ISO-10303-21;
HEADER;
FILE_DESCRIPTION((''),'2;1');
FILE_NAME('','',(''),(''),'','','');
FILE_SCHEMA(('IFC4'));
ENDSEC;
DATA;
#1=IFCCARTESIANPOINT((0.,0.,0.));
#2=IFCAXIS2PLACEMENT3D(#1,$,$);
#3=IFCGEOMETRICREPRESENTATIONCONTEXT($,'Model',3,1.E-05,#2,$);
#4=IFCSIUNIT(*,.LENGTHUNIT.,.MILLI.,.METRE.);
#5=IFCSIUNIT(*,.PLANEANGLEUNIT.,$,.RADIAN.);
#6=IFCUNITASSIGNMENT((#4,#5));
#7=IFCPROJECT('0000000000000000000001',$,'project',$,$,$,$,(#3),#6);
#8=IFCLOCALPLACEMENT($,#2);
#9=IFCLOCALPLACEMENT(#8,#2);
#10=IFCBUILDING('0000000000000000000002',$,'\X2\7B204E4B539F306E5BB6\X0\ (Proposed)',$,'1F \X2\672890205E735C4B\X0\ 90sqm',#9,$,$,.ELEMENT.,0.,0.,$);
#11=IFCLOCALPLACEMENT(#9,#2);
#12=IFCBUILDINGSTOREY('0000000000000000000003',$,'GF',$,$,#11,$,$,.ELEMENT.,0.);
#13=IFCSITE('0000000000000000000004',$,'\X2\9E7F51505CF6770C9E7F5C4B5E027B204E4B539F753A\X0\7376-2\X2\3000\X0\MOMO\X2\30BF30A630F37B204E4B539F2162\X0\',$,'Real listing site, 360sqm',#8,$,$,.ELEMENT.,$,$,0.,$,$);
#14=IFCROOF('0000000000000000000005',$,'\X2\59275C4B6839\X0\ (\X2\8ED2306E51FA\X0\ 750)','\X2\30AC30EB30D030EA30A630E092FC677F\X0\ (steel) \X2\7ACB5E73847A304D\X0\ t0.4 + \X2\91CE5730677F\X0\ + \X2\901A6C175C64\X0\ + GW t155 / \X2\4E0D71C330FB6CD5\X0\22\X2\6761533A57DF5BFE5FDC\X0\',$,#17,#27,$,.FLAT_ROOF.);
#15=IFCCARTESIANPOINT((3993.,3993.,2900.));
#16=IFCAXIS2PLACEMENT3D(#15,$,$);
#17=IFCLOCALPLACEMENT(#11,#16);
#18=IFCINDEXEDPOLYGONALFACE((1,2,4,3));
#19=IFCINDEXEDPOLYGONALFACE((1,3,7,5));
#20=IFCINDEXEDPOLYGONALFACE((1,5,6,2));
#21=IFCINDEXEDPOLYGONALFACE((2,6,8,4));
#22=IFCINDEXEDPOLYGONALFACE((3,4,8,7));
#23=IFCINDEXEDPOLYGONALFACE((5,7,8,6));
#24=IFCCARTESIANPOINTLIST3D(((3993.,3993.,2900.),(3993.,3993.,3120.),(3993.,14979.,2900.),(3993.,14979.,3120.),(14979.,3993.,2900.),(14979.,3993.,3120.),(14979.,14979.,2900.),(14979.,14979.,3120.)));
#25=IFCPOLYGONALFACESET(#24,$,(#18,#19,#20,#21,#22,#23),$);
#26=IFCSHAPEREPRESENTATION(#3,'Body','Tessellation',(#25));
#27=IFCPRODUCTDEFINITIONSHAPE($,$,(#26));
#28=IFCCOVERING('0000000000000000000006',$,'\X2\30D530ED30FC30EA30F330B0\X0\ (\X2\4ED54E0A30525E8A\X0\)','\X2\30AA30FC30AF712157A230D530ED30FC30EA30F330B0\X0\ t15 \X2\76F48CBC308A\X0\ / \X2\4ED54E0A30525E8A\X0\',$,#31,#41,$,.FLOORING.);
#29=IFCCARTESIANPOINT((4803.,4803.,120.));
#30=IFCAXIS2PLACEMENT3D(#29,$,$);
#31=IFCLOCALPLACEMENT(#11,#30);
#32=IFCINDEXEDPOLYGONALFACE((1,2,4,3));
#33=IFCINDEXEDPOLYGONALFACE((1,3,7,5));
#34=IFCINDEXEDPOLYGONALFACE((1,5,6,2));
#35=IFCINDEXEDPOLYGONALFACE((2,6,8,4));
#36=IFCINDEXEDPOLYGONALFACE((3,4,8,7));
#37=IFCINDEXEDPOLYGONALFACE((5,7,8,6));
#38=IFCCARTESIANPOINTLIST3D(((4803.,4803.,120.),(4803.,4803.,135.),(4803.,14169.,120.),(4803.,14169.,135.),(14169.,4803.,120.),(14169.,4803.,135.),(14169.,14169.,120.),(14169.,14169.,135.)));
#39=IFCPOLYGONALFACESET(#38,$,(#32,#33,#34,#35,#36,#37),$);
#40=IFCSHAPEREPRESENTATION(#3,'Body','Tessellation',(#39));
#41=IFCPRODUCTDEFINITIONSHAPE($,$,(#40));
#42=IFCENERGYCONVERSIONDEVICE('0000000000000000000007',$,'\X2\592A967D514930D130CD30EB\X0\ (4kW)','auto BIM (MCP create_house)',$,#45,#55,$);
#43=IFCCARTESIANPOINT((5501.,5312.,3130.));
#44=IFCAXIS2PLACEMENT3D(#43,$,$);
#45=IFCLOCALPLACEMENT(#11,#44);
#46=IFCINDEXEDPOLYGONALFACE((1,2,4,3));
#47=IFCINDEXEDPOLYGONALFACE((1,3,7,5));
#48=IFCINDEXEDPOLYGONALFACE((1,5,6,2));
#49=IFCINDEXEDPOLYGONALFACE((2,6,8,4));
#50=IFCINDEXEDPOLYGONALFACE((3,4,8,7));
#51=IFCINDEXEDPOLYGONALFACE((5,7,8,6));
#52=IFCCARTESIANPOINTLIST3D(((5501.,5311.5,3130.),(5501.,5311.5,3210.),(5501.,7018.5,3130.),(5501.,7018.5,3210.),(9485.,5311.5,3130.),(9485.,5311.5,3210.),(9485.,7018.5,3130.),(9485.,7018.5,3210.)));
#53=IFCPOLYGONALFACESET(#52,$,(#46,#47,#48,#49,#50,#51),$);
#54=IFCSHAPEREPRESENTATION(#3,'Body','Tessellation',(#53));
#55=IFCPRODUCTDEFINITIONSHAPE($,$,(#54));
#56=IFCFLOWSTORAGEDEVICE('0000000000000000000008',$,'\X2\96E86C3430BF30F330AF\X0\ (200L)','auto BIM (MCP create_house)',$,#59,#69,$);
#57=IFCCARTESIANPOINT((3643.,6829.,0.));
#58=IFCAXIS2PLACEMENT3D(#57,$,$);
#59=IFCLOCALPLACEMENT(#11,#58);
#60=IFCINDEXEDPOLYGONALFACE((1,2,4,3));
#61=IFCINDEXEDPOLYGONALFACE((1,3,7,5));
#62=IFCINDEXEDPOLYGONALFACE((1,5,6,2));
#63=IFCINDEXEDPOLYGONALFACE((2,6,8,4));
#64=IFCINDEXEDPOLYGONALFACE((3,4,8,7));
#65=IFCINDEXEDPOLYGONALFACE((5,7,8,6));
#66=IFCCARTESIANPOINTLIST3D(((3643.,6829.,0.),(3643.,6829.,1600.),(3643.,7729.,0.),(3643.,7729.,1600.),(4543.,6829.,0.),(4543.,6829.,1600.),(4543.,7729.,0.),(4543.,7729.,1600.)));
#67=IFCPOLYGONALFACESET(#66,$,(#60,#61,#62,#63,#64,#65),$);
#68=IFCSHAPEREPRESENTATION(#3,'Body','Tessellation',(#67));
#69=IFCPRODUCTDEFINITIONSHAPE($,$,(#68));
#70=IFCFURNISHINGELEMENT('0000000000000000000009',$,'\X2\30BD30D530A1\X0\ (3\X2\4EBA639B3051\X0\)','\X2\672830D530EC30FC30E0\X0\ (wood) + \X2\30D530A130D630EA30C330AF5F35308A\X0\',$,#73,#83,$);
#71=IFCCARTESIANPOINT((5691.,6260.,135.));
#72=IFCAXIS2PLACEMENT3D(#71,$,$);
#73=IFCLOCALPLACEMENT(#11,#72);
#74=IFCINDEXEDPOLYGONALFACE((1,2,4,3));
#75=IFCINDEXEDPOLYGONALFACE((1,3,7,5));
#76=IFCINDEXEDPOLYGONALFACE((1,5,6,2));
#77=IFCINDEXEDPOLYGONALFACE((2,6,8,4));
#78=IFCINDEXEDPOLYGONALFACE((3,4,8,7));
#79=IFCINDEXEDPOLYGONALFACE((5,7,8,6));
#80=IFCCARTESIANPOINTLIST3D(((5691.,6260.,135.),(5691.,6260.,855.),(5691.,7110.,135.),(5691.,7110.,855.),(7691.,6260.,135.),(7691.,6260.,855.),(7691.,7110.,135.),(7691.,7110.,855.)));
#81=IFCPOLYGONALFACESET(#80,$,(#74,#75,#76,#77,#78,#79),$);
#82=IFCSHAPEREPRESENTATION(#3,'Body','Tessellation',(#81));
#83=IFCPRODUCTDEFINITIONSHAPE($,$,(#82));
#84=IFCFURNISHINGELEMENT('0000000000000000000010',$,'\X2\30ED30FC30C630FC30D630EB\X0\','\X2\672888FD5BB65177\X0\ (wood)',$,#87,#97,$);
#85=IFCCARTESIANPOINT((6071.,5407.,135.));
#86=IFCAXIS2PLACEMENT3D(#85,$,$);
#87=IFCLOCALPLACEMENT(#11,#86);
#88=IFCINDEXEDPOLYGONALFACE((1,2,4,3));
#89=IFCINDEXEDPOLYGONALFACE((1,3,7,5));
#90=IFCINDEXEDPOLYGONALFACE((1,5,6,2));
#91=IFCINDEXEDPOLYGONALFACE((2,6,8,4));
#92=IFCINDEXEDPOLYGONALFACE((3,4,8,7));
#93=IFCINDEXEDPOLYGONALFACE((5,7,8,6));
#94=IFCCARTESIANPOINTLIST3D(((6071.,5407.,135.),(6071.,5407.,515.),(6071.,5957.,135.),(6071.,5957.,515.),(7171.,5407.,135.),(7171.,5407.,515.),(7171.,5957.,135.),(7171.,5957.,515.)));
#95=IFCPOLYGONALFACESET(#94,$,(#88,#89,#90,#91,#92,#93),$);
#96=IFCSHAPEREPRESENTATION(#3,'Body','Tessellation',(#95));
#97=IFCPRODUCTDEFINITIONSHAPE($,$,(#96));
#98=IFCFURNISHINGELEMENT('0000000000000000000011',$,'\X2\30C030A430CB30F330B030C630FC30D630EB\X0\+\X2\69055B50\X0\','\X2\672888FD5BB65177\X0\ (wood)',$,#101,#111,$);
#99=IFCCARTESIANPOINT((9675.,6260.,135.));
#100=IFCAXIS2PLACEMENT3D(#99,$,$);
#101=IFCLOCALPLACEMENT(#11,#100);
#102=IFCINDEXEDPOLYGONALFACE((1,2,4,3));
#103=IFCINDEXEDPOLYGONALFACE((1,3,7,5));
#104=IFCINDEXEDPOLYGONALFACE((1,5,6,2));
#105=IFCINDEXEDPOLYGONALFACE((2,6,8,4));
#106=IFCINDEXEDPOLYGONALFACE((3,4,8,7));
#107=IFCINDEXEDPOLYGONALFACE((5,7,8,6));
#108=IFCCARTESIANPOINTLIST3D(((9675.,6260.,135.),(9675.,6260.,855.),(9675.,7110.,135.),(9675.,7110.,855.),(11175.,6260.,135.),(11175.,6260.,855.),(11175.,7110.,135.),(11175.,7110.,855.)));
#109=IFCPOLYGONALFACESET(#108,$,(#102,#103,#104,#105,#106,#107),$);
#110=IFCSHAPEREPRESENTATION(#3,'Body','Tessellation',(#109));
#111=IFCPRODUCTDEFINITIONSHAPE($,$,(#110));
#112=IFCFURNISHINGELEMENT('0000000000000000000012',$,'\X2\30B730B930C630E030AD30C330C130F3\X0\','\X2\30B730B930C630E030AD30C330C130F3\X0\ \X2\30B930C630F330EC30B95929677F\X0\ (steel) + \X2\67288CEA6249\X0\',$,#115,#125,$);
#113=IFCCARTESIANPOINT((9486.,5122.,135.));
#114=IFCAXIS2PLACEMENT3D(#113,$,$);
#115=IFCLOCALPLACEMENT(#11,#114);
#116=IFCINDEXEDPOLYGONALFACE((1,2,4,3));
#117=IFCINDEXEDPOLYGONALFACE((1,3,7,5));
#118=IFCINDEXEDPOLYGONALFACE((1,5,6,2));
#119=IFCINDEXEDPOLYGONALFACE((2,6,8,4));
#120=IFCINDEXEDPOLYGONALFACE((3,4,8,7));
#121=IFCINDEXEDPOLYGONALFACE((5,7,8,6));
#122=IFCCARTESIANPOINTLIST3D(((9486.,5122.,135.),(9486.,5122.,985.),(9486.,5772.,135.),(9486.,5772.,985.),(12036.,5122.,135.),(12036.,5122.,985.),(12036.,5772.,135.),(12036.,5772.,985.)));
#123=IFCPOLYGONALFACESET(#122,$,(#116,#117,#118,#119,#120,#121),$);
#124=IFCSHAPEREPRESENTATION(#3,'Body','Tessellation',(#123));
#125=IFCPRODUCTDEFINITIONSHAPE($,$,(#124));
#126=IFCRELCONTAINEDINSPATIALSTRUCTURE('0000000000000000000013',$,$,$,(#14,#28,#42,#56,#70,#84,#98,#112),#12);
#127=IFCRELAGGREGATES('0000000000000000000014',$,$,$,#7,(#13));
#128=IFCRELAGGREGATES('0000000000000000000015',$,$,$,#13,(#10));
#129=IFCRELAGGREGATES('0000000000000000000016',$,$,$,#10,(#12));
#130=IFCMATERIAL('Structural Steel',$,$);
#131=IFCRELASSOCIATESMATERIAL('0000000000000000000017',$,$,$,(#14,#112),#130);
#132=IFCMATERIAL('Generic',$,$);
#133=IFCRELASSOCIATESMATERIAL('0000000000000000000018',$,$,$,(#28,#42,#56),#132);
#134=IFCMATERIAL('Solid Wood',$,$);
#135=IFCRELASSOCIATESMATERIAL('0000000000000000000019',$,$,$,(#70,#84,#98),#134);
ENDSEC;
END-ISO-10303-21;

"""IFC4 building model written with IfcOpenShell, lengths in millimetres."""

from ifc_helpers import new_model, si_unit, frame, frame_2d, origin, place, context, project, spatial, rectangle, extrude, material, element, save


model = new_model("IFC4")

# Units and contexts
model_context = context("Model", 3, precision=1e-05, world=origin())
ifc_project = project(units=[si_unit("LENGTHUNIT", "METRE", prefix="MILLI"), si_unit("PLANEANGLEUNIT", "RADIAN")], contexts=[model_context])

# Site, building, storey
site_placement = place(None, origin())
site = spatial("IfcSite", under=ifc_project, at=site_placement, Name="鹿児島県鹿屋市笠之原町7376-2　MOMOタウン笠之原Ⅲ", ObjectType="Real listing site, 360sqm", CompositionType="ELEMENT", RefElevation=0.0)
building_placement = place(site_placement, origin())
building = spatial("IfcBuilding", under=site, at=building_placement, Name="笠之原の家 (Proposed)", ObjectType="1F 木造平屋 90sqm", CompositionType="ELEMENT", ElevationOfRefHeight=0.0, ElevationOfTerrain=0.0)
storey_placement = place(building_placement, origin())
storey = spatial("IfcBuildingStorey", under=building, at=storey_placement, Name="GF", CompositionType="ELEMENT", Elevation=0.0)

# Shared definitions
ifc_material_1 = material(Name="Solid Wood")

# Roof
ifc_material_2 = material(Name="Structural Steel")
roof_placement = place(storey_placement, frame((3993.0, 3993.0, 2900.0)))
element("IfcRoof", 1, at=roof_placement, inside=storey, material=ifc_material_2, Name="大屋根 (軒の出 750)", Description="ガルバリウム鋼板 (steel) 立平葺き t0.4 + 野地板 + 通気層 + GW t155 / 不燃・法22条区域対応", PredefinedType="FLAT_ROOF", context=model_context, shape_type="SweptSolid", body=[
    extrude(rectangle(XDim=10986.0, YDim=10986.0, at=frame_2d((5493.0, 5493.0))), frame((3993.0, 3993.0, 2900.0)), (0.0, 0.0, 1.0), 220.0),
])

# Covering
ifc_material_3 = material(Name="Generic")
covering_placement = place(storey_placement, frame((4803.0, 4803.0, 120.0)))
element("IfcCovering", 2, at=covering_placement, inside=storey, material=ifc_material_3, Name="フローリング (仕上げ床)", Description="オーク無垢フローリング t15 直貼り / 仕上げ床", PredefinedType="FLOORING", context=model_context, shape_type="SweptSolid", body=[
    extrude(rectangle(XDim=9366.0, YDim=9366.0, at=frame_2d((4683.0, 4683.0))), frame((4803.0, 4803.0, 120.0)), (0.0, 0.0, 1.0), 15.0),
])

# Energy conversion device
energy_conversion_device_placement = place(storey_placement, frame((5501.0, 5312.0, 3130.0)))
element("IfcEnergyConversionDevice", 3, at=energy_conversion_device_placement, inside=storey, material=ifc_material_3, Name="太陽光パネル (4kW)", Description="auto BIM (MCP create_house)", context=model_context, shape_type="SweptSolid", body=[
    extrude(rectangle(XDim=3984.0, YDim=1707.0, at=frame_2d((1992.0, 853.0))), frame((5501.0, 5312.0, 3130.0)), (0.0, 0.0, 1.0), 80.0),
])

# Flow storage device
flow_storage_device_placement = place(storey_placement, frame((3643.0, 6829.0, 0.0)))
element("IfcFlowStorageDevice", 4, at=flow_storage_device_placement, inside=storey, material=ifc_material_3, Name="雨水タンク (200L)", Description="auto BIM (MCP create_house)", context=model_context, shape_type="SweptSolid", body=[
    extrude(rectangle(XDim=900.0, YDim=900.0, at=frame_2d((450.0, 450.0))), frame((3643.0, 6829.0, 0.0)), (0.0, 0.0, 1.0), 1600.0),
])

# Furnishing elements
furnishing_1_placement = place(storey_placement, frame((5691.0, 6260.0, 135.0)))
element("IfcFurnishingElement", 5, at=furnishing_1_placement, inside=storey, material=ifc_material_1, Name="ソファ (3人掛け)", Description="木フレーム (wood) + ファブリック張り", context=model_context, shape_type="SweptSolid", body=[
    extrude(rectangle(XDim=2000.0, YDim=850.0, at=frame_2d((1000.0, 425.0))), frame((5691.0, 6260.0, 135.0)), (0.0, 0.0, 1.0), 720.0),
])
furnishing_2_placement = place(storey_placement, frame((6071.0, 5407.0, 135.0)))
element("IfcFurnishingElement", 6, at=furnishing_2_placement, inside=storey, material=ifc_material_1, Name="ローテーブル", Description="木製家具 (wood)", context=model_context, shape_type="SweptSolid", body=[
    extrude(rectangle(XDim=1100.0, YDim=550.0, at=frame_2d((550.0, 275.0))), frame((6071.0, 5407.0, 135.0)), (0.0, 0.0, 1.0), 380.0),
])
furnishing_3_placement = place(storey_placement, frame((9675.0, 6260.0, 135.0)))
element("IfcFurnishingElement", 7, at=furnishing_3_placement, inside=storey, material=ifc_material_1, Name="ダイニングテーブル+椅子", Description="木製家具 (wood)", context=model_context, shape_type="SweptSolid", body=[
    extrude(rectangle(XDim=1500.0, YDim=850.0, at=frame_2d((750.0, 425.0))), frame((9675.0, 6260.0, 135.0)), (0.0, 0.0, 1.0), 720.0),
])
furnishing_4_placement = place(storey_placement, frame((9486.0, 5122.0, 135.0)))
element("IfcFurnishingElement", 8, at=furnishing_4_placement, inside=storey, material=ifc_material_2, Name="システムキッチン", Description="システムキッチン ステンレス天板 (steel) + 木質扉", context=model_context, shape_type="SweptSolid", body=[
    extrude(rectangle(XDim=2550.0, YDim=650.0, at=frame_2d((1275.0, 325.0))), frame((9486.0, 5122.0, 135.0)), (0.0, 0.0, 1.0), 850.0),
])

save(model, "model.ifc")
